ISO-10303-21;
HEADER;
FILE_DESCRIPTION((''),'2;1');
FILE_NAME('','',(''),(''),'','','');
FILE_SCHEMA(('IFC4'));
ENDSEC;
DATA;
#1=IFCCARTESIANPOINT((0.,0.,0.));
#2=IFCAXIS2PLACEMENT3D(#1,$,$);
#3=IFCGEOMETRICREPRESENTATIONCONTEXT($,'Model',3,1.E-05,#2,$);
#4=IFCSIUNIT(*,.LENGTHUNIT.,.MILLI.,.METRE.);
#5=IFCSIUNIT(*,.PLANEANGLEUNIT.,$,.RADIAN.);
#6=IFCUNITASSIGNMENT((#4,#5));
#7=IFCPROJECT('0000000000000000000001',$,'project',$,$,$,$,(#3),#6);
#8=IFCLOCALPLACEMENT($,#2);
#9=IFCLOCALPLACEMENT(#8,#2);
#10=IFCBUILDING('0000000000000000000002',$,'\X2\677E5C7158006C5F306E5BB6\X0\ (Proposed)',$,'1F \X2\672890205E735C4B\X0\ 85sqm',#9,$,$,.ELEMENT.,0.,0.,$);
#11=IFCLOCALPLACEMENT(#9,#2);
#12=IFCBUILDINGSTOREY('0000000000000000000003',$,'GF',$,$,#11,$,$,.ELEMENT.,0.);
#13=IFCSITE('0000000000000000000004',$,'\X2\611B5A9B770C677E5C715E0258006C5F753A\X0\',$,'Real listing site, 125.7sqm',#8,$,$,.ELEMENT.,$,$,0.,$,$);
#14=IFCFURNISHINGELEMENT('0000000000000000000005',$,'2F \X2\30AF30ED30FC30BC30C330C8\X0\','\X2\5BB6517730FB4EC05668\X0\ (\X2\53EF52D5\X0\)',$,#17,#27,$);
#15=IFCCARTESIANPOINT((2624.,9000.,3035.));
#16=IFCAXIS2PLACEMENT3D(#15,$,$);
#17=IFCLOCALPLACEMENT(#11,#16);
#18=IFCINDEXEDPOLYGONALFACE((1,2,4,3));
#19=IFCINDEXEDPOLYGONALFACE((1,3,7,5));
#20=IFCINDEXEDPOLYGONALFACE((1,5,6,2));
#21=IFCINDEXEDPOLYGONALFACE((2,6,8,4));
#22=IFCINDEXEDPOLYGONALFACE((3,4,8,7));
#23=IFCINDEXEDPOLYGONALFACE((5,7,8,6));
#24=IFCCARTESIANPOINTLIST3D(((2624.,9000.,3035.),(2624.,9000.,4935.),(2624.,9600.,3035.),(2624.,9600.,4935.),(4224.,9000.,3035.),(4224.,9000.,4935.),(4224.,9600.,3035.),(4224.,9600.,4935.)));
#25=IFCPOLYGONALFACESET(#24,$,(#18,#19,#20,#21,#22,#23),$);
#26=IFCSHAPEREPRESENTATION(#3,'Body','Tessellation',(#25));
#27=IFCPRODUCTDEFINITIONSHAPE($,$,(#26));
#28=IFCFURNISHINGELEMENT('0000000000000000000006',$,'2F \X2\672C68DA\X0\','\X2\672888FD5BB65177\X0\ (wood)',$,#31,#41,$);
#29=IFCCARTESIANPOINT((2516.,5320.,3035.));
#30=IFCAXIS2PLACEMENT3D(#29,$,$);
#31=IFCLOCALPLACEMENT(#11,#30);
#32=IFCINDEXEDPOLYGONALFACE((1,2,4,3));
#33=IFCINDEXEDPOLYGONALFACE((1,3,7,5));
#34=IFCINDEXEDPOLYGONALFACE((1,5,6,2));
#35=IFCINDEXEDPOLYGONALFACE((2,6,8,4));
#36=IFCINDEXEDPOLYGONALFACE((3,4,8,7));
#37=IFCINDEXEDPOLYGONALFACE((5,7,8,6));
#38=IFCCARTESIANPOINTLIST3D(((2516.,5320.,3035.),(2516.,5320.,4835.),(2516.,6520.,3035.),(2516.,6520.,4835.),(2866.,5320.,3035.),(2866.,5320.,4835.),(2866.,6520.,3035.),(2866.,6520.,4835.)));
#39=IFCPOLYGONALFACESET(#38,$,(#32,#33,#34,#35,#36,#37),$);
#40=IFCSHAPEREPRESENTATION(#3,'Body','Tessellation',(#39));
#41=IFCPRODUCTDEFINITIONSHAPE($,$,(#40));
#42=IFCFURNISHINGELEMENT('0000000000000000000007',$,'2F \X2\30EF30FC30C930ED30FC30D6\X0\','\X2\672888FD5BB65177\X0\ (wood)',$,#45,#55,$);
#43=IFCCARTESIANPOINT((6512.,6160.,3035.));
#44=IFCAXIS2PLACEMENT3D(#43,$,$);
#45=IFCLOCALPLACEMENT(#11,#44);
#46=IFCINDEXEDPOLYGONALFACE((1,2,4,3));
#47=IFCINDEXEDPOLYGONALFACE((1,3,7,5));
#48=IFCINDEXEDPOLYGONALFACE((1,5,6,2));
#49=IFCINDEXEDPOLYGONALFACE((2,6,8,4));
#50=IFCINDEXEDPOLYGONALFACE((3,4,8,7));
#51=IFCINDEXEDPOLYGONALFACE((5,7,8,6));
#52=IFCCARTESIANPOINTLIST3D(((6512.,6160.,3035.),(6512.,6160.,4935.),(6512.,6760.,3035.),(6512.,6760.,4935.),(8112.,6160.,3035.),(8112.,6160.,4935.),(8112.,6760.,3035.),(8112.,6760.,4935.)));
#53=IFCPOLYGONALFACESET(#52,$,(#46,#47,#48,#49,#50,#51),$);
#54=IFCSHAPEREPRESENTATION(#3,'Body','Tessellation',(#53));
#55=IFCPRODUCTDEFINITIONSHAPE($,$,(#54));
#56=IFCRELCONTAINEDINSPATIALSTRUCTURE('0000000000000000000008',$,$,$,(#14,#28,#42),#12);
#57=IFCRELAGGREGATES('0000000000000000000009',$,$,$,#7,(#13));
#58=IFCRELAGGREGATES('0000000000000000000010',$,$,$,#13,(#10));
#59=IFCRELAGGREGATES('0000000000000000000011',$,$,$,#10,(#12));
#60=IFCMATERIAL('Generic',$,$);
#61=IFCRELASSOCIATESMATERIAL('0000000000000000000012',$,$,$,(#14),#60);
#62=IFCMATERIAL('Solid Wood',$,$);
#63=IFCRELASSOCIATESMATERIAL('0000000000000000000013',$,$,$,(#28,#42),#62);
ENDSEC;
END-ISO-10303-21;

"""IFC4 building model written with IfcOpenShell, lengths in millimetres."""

from ifc_helpers import new_model, si_unit, frame, frame_2d, origin, place, context, project, spatial, rectangle, extrude, material, element, save


model = new_model("IFC4")

# Units and contexts
model_context = context("Model", 3, precision=1e-05, world=origin())
ifc_project = project(units=[si_unit("LENGTHUNIT", "METRE", prefix="MILLI"), si_unit("PLANEANGLEUNIT", "RADIAN")], contexts=[model_context])

# Site, building, storey
site_placement = place(None, origin())
site = spatial("IfcSite", under=ifc_project, at=site_placement, Name="愛媛県松山市堀江町", ObjectType="Real listing site, 125.7sqm", CompositionType="ELEMENT", RefElevation=0.0)
building_placement = place(site_placement, origin())
building = spatial("IfcBuilding", under=site, at=building_placement, Name="松山堀江の家 (Proposed)", ObjectType="1F 木造平屋 85sqm", CompositionType="ELEMENT", ElevationOfRefHeight=0.0, ElevationOfTerrain=0.0)
storey_placement = place(building_placement, origin())
storey = spatial("IfcBuildingStorey", under=building, at=storey_placement, Name="GF", CompositionType="ELEMENT", Elevation=0.0)

# Shared definitions
ifc_material_1 = material(Name="Solid Wood")

# Shared definitions
ifc_material_2 = material(Name="Generic")

# Furnishing elements
furnishing_1_placement = place(storey_placement, frame((2624.0, 9000.0, 3035.0)))
element("IfcFurnishingElement", 1, at=furnishing_1_placement, inside=storey, material=ifc_material_2, Name="2F クローゼット", Description="家具・什器 (可動)", context=model_context, shape_type="SweptSolid", body=[
    extrude(rectangle(XDim=1600.0, YDim=600.0, at=frame_2d((800.0, 300.0))), frame((2624.0, 9000.0, 3035.0)), (0.0, 0.0, 1.0), 1900.0),
])
furnishing_2_placement = place(storey_placement, frame((2516.0, 5320.0, 3035.0)))
element("IfcFurnishingElement", 2, at=furnishing_2_placement, inside=storey, material=ifc_material_1, Name="2F 本棚", Description="木製家具 (wood)", context=model_context, shape_type="SweptSolid", body=[
    extrude(rectangle(XDim=350.0, YDim=1200.0, at=frame_2d((175.0, 600.0))), frame((2516.0, 5320.0, 3035.0)), (0.0, 0.0, 1.0), 1800.0),
])
furnishing_3_placement = place(storey_placement, frame((6512.0, 6160.0, 3035.0)))
element("IfcFurnishingElement", 3, at=furnishing_3_placement, inside=storey, material=ifc_material_1, Name="2F ワードローブ", Description="木製家具 (wood)", context=model_context, shape_type="SweptSolid", body=[
    extrude(rectangle(XDim=1600.0, YDim=600.0, at=frame_2d((800.0, 300.0))), frame((6512.0, 6160.0, 3035.0)), (0.0, 0.0, 1.0), 1900.0),
])

save(model, "model.ifc")
